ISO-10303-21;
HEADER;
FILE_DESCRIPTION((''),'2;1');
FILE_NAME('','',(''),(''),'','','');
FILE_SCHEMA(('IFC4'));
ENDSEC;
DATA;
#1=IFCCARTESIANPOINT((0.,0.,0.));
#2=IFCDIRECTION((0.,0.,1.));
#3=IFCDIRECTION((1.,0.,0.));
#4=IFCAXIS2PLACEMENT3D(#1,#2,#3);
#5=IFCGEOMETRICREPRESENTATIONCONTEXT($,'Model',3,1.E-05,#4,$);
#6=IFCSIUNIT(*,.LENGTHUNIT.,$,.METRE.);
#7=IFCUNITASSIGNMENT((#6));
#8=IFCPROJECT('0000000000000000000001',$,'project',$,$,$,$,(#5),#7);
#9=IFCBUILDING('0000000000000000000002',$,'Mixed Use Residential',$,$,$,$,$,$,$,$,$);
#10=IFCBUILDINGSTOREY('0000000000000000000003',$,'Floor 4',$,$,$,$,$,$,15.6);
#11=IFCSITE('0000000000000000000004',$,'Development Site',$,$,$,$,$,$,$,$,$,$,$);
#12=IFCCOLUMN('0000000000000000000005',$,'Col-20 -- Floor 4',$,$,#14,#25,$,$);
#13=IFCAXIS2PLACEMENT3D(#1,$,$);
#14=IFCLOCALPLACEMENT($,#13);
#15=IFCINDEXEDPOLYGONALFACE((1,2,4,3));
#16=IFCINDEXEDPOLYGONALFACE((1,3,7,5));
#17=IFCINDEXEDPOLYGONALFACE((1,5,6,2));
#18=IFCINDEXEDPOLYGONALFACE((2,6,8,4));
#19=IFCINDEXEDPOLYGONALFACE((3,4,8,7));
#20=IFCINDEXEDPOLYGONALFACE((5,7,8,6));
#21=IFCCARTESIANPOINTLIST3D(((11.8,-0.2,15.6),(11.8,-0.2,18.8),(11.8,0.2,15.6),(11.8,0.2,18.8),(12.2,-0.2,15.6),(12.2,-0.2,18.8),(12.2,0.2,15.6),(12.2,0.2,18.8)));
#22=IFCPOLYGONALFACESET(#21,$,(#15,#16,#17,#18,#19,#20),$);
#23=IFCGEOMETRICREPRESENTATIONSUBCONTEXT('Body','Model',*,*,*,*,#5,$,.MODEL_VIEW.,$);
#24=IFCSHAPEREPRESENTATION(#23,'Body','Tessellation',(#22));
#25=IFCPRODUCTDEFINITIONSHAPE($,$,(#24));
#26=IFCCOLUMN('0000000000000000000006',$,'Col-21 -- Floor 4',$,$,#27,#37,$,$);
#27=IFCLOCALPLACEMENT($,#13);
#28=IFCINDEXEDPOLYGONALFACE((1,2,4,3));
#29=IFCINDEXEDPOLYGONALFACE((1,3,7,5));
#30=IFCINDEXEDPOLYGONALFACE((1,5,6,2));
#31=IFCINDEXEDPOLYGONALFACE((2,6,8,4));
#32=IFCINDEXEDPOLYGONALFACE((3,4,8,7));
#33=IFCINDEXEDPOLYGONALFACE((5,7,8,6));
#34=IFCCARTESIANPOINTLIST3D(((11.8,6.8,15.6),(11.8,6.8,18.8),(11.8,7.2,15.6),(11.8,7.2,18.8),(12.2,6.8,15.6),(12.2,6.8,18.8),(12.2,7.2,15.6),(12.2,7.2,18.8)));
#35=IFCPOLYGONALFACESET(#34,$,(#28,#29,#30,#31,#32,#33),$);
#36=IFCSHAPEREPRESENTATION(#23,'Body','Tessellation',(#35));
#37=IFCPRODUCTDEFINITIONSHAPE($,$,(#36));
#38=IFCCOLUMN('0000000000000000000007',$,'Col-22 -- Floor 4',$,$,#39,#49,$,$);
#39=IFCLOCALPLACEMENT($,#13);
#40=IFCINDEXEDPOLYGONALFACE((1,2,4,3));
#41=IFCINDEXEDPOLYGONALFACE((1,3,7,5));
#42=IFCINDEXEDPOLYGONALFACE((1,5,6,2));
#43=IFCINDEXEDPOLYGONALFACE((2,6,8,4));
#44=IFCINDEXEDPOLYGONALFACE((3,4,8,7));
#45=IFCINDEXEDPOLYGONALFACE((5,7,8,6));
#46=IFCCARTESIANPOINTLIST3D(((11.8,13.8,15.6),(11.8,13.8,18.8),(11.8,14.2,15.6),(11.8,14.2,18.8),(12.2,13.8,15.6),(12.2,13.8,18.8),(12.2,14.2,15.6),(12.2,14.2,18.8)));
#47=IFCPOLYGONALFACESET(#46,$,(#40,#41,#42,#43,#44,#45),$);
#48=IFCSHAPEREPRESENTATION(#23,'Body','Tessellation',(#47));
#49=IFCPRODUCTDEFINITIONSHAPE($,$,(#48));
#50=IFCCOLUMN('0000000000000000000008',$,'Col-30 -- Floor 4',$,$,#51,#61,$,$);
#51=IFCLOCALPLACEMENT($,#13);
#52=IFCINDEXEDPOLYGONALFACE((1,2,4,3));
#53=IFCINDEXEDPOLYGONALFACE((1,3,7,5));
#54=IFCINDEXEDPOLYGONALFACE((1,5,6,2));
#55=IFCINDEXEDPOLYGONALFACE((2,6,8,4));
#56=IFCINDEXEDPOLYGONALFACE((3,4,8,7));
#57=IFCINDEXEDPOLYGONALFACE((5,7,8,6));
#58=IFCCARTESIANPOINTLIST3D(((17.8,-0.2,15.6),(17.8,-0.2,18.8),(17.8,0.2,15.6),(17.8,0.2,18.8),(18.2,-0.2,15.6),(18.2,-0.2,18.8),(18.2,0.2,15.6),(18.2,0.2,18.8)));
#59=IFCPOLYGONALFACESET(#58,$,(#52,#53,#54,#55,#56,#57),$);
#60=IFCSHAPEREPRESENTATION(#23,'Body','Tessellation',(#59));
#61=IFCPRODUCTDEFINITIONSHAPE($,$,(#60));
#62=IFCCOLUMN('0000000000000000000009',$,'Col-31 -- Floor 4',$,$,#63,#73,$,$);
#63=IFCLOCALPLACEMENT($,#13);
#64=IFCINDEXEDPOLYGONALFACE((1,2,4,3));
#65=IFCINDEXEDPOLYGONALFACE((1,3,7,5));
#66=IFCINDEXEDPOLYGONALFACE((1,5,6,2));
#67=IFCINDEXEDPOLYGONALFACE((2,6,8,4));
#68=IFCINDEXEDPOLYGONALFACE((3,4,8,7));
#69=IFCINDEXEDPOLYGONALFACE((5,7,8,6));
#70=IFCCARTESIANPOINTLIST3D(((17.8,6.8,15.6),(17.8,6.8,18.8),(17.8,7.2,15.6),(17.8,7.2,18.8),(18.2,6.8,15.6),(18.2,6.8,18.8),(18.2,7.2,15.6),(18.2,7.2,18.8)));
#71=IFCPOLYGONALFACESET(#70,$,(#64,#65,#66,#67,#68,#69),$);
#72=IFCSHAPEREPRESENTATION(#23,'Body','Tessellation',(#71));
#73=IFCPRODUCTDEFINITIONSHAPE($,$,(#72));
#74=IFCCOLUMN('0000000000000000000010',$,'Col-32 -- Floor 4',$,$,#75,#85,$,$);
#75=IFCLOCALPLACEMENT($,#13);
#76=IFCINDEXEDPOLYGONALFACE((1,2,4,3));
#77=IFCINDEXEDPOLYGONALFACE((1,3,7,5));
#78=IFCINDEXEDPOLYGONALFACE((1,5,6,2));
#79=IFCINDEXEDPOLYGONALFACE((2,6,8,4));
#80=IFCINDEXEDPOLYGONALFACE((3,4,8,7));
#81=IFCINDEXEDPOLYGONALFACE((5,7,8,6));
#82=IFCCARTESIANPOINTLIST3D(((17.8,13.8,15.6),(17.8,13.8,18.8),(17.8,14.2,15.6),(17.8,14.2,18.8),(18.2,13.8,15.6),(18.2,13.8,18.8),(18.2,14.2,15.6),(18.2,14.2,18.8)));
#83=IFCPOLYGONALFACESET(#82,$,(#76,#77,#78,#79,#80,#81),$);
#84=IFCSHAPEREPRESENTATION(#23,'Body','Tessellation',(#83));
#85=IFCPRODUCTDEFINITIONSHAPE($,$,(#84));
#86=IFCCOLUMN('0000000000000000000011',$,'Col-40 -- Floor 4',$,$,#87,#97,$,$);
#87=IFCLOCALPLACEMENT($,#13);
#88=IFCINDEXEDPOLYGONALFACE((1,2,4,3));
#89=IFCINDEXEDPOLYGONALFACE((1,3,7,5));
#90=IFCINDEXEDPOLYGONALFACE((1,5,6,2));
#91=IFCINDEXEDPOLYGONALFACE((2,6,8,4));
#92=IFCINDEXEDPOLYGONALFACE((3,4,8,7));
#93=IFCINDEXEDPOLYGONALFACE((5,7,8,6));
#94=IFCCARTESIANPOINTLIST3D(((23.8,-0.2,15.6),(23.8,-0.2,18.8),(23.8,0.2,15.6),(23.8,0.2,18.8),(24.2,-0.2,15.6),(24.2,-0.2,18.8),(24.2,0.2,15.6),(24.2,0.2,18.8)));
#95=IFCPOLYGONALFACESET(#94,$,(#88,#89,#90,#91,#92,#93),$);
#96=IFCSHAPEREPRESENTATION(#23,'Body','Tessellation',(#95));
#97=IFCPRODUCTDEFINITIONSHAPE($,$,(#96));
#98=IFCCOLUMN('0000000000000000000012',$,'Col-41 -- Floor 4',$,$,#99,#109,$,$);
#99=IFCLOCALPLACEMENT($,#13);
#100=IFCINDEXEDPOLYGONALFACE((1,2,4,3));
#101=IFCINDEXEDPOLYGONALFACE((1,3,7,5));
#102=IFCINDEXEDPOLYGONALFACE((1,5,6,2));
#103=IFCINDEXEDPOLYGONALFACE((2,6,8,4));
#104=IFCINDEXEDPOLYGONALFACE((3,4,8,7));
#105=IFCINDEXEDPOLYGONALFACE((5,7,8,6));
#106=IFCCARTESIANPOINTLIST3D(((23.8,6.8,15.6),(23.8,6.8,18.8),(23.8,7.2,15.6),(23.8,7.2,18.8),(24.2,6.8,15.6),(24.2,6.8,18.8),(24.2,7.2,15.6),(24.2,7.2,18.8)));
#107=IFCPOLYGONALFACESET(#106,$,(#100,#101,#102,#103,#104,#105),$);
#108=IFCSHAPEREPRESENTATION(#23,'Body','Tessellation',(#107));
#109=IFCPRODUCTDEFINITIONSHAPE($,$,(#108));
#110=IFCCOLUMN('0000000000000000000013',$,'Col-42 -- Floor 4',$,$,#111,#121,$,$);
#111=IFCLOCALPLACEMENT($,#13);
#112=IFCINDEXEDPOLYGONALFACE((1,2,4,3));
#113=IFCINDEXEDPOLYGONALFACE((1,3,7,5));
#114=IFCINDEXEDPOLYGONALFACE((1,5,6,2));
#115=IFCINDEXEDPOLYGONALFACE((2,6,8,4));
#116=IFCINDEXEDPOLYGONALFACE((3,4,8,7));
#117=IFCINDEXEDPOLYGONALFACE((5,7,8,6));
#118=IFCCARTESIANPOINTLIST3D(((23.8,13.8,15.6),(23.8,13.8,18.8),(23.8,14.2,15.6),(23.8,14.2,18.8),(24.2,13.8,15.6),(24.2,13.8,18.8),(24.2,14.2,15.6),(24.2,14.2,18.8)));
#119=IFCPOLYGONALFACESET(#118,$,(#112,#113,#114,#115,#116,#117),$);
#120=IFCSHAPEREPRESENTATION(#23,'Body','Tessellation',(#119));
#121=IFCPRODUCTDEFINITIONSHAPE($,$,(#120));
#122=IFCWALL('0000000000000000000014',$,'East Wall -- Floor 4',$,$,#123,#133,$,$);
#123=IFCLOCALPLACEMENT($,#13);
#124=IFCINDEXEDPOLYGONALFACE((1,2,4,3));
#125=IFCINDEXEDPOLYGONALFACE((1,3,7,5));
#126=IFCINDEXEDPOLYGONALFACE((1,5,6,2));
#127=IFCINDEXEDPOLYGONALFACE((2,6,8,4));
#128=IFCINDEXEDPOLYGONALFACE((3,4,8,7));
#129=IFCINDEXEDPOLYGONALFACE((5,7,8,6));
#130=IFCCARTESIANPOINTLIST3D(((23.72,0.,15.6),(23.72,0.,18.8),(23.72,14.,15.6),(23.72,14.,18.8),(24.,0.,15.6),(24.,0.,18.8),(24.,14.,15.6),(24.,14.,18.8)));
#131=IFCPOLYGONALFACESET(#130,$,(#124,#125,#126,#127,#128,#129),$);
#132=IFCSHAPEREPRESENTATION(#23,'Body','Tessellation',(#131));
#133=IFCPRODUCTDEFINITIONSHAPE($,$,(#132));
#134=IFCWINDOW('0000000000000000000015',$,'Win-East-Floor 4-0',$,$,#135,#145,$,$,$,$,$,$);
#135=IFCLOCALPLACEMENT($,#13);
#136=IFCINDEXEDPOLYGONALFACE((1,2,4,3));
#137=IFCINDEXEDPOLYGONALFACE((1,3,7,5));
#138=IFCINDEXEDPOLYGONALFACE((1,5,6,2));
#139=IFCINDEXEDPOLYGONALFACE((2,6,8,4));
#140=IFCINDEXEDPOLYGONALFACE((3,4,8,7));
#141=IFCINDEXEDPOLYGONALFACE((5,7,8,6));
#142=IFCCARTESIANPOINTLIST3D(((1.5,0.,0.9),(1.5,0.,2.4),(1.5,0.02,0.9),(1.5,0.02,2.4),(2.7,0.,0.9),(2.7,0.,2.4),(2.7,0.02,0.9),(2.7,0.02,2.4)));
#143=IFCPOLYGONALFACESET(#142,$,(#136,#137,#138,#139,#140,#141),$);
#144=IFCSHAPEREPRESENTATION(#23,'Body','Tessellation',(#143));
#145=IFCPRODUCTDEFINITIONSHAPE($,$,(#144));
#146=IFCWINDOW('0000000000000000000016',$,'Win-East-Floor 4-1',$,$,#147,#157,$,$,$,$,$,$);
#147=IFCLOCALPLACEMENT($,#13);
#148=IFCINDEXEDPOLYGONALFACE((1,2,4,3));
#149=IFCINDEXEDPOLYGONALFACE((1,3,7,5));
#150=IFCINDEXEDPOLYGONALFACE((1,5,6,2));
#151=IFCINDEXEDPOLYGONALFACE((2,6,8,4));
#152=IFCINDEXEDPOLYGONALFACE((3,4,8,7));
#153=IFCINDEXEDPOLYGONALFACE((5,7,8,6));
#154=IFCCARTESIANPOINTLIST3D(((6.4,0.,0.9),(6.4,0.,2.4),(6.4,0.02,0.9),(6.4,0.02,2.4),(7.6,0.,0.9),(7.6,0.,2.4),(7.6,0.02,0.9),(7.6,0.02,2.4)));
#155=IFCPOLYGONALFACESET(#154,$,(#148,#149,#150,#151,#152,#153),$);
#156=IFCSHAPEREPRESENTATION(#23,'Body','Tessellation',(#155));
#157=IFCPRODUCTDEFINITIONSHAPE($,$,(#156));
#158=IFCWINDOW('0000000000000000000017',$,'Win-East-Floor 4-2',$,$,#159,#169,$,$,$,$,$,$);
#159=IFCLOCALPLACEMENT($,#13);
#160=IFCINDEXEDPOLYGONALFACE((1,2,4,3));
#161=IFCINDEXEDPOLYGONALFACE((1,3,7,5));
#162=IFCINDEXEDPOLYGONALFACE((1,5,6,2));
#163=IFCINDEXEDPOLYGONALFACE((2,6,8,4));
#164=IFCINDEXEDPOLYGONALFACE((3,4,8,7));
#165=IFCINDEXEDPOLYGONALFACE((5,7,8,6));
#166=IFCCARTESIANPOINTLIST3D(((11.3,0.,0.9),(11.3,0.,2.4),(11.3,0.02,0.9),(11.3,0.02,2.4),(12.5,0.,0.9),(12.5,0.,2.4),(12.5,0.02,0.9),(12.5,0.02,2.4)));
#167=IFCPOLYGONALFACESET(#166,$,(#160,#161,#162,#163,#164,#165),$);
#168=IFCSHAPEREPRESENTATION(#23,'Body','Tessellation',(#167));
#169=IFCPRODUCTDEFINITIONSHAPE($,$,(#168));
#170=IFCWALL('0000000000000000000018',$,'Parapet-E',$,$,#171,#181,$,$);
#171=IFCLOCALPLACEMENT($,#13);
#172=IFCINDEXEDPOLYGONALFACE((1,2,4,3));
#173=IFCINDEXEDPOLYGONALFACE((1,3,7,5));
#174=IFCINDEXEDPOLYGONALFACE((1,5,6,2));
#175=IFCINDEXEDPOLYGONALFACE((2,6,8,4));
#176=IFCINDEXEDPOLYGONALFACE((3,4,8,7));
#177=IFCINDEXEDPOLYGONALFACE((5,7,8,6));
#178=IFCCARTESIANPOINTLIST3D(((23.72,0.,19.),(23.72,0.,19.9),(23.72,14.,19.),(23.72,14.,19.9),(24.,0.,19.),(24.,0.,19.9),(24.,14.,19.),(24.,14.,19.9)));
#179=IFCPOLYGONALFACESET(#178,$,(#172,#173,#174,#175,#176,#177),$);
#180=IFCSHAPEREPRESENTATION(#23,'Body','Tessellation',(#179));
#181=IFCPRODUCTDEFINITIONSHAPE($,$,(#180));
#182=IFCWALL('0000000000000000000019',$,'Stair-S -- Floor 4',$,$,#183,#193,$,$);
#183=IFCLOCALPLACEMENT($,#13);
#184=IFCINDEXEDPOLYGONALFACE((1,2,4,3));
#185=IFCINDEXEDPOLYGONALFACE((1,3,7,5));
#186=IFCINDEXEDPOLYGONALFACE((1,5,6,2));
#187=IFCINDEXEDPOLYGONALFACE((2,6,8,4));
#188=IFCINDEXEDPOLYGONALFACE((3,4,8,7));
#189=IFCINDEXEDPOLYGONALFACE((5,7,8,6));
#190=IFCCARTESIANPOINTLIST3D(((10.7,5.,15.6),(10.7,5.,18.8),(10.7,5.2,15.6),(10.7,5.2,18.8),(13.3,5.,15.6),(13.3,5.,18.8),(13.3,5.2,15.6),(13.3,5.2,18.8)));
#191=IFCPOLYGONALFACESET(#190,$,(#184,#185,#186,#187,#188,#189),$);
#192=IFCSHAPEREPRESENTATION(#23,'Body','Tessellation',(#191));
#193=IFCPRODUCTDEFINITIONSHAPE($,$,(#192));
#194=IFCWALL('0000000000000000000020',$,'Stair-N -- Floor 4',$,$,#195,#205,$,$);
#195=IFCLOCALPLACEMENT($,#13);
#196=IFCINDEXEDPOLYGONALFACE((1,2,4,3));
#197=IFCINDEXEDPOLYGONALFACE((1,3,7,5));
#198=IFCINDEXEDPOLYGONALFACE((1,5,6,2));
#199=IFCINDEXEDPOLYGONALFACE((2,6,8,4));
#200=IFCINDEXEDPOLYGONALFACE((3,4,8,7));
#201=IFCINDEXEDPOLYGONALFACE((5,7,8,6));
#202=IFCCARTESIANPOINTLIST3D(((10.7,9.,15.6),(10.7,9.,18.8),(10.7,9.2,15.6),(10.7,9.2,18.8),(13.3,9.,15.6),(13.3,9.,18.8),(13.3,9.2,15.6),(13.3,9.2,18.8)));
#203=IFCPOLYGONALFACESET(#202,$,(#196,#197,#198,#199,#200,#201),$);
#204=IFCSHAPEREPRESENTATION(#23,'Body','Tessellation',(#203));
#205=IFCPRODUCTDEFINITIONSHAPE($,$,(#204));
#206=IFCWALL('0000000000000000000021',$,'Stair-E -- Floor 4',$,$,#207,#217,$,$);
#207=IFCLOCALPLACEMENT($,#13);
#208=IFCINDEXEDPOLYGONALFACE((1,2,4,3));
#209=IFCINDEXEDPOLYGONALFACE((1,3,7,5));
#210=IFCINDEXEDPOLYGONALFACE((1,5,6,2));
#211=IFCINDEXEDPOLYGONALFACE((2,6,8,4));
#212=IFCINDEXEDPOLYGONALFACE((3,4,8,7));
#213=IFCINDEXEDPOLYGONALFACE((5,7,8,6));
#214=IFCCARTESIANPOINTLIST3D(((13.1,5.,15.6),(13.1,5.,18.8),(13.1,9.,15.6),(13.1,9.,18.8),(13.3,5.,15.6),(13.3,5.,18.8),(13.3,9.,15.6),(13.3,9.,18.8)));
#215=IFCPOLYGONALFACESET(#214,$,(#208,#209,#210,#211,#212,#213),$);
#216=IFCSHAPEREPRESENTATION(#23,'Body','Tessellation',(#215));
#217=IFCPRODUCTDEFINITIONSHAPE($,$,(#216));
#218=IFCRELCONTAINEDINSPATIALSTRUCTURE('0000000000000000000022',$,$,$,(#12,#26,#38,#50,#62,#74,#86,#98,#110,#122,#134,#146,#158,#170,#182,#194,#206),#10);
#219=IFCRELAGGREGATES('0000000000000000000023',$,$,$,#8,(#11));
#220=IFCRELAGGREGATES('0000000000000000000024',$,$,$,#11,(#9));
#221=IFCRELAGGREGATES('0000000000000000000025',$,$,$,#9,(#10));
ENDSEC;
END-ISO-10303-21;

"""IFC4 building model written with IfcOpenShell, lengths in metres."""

from ifc_helpers import new_model, si_unit, frame, origin_with_axes, place, context, subcontext, project, spatial, indexed_curve, rectangle, outline, extrude, element, fill, save


model = new_model("IFC4")

# Units and contexts
model_context = context("Model", 3, precision=1e-05, world=origin_with_axes())
body_context = subcontext(model_context, "Body", "Model", "MODEL_VIEW")
ifc_project = project(units=[si_unit("LENGTHUNIT", "METRE")], contexts=[model_context])

# Site, building, storey
site = spatial("IfcSite", under=ifc_project, Name="Development Site")
building = spatial("IfcBuilding", under=site, Name="Mixed Use Residential")
storey = spatial("IfcBuildingStorey", under=building, Name="Floor 4", Elevation=15.6)

# Columns
for number, where, z_axis, x_axis, name in (
    (1, (12.0, 0.0, 15.6), (0.0, 0.0, 1.0), (1.0, 0.0, 0.0), "Col-20 -- Floor 4"),
    (2, (12.0, 7.0, 15.6), (0.0, 0.0, 1.0), (1.0, 0.0, 0.0), "Col-21 -- Floor 4"),
    (3, (12.0, 14.0, 15.6), (0.0, 0.0, 1.0), (1.0, 0.0, 0.0), "Col-22 -- Floor 4"),
    (4, (18.0, 0.0, 15.6), (0.0, 0.0, 1.0), (1.0, 0.0, 0.0), "Col-30 -- Floor 4"),
    (5, (18.0, 7.0, 15.6), (0.0, 0.0, 1.0), (1.0, 0.0, 0.0), "Col-31 -- Floor 4"),
    (6, (18.0, 14.0, 15.6), (0.0, 0.0, 1.0), (1.0, 0.0, 0.0), "Col-32 -- Floor 4"),
    (7, (24.0, 0.0, 15.6), (0.0, 0.0, 1.0), (1.0, 0.0, 0.0), "Col-40 -- Floor 4"),
    (8, (24.0, 7.0, 15.6), (0.0, 0.0, 1.0), (1.0, 0.0, 0.0), "Col-41 -- Floor 4"),
    (9, (24.0, 14.0, 15.6), (0.0, 0.0, 1.0), (1.0, 0.0, 0.0), "Col-42 -- Floor 4"),
):
    element("IfcColumn", number, at=place(None, frame(where, z_axis=z_axis, x_axis=x_axis)), inside=storey, Name=name, context=body_context, shape_type="SweptSolid", body=[
        extrude(rectangle(XDim=0.4, YDim=0.4), origin_with_axes(), (0.0, 0.0, 1.0), 3.2),
    ])

# Wall, openings, windows
wall_1_placement = place(None, frame((24.0, 0.0, 15.6), z_axis=(0.0, 0.0, 1.0), x_axis=(0.0, 1.0, 0.0)))
wall_1 = element("IfcWall", 10, at=wall_1_placement, inside=storey, Name="East Wall -- Floor 4", context=body_context, shape_type="SweptSolid", body=[
    extrude(outline(indexed_curve([(0.0, 0.0), (0.0, 0.28), (14.0, 0.28), (14.0, 0.0), (0.0, 0.0)], self_intersect=False)), origin_with_axes(), (0.0, 0.0, 1.0), 3.2),
])
opening_1_placement = place(wall_1_placement, frame((0.0, 22.5, -14.7), z_axis=(0.0, 0.0, 1.0), x_axis=(0.0, -1.0, 0.0)))
opening_1 = element("IfcOpeningElement", 11, at=opening_1_placement, cuts=wall_1, context=body_context, shape_type="SweptSolid", body=[
    extrude(outline(indexed_curve([(0.0, 0.0), (0.0, 0.28), (1.2, 0.28), (1.2, 0.0), (0.0, 0.0)], self_intersect=False)), origin_with_axes(), (0.0, 0.0, 1.0), 1.5),
])
opening_2_placement = place(wall_1_placement, frame((0.0, 17.6, -14.7), z_axis=(0.0, 0.0, 1.0), x_axis=(0.0, -1.0, 0.0)))
opening_2 = element("IfcOpeningElement", 12, at=opening_2_placement, cuts=wall_1, context=body_context, shape_type="SweptSolid", body=[
    extrude(outline(indexed_curve([(0.0, 0.0), (0.0, 0.28), (1.2, 0.28), (1.2, 0.0), (0.0, 0.0)], self_intersect=False)), origin_with_axes(), (0.0, 0.0, 1.0), 1.5),
])
opening_3_placement = place(wall_1_placement, frame((0.0, 12.7, -14.7), z_axis=(0.0, 0.0, 1.0), x_axis=(0.0, -1.0, 0.0)))
opening_3 = element("IfcOpeningElement", 13, at=opening_3_placement, cuts=wall_1, context=body_context, shape_type="SweptSolid", body=[
    extrude(outline(indexed_curve([(0.0, 0.0), (0.0, 0.28), (1.2, 0.28), (1.2, 0.0), (0.0, 0.0)], self_intersect=False)), origin_with_axes(), (0.0, 0.0, 1.0), 1.5),
])
window_1_placement = place(None, frame((1.5, 0.0, 0.9), z_axis=(0.0, 0.0, 1.0), x_axis=(1.0, 0.0, 0.0)))
window_1 = element("IfcWindow", 14, at=window_1_placement, inside=storey, Name="Win-East-Floor 4-0", context=body_context, shape_type="SweptSolid", body=[
    extrude(outline(indexed_curve([(0.0, 0.0), (0.0, 0.02), (1.2, 0.02), (1.2, 0.0), (0.0, 0.0)], self_intersect=False)), origin_with_axes(), (0.0, 0.0, 1.0), 1.5),
])
fill(opening_1, window_1)
window_2_placement = place(None, frame((6.4, 0.0, 0.9), z_axis=(0.0, 0.0, 1.0), x_axis=(1.0, 0.0, 0.0)))
window_2 = element("IfcWindow", 15, at=window_2_placement, inside=storey, Name="Win-East-Floor 4-1", context=body_context, shape_type="SweptSolid", body=[
    extrude(outline(indexed_curve([(0.0, 0.0), (0.0, 0.02), (1.2, 0.02), (1.2, 0.0), (0.0, 0.0)], self_intersect=False)), origin_with_axes(), (0.0, 0.0, 1.0), 1.5),
])
fill(opening_2, window_2)
window_3_placement = place(None, frame((11.3, 0.0, 0.9), z_axis=(0.0, 0.0, 1.0), x_axis=(1.0, 0.0, 0.0)))
window_3 = element("IfcWindow", 16, at=window_3_placement, inside=storey, Name="Win-East-Floor 4-2", context=body_context, shape_type="SweptSolid", body=[
    extrude(outline(indexed_curve([(0.0, 0.0), (0.0, 0.02), (1.2, 0.02), (1.2, 0.0), (0.0, 0.0)], self_intersect=False)), origin_with_axes(), (0.0, 0.0, 1.0), 1.5),
])
fill(opening_3, window_3)

# Walls
wall_2_placement = place(None, frame((24.0, 0.0, 19.0), z_axis=(0.0, 0.0, 1.0), x_axis=(0.0, 1.0, 0.0)))
element("IfcWall", 17, at=wall_2_placement, inside=storey, Name="Parapet-E", context=body_context, shape_type="SweptSolid", body=[
    extrude(outline(indexed_curve([(0.0, 0.0), (0.0, 0.28), (14.0, 0.28), (14.0, 0.0), (0.0, 0.0)], self_intersect=False)), origin_with_axes(), (0.0, 0.0, 1.0), 0.9),
])
for number, where, z_axis, x_axis, name in (
    (18, (10.7, 5.0, 15.6), (0.0, 0.0, 1.0), (1.0, 0.0, 0.0), "Stair-S -- Floor 4"),
    (19, (10.7, 9.0, 15.6), (0.0, 0.0, 1.0), (1.0, 0.0, 0.0), "Stair-N -- Floor 4"),
):
    element("IfcWall", number, at=place(None, frame(where, z_axis=z_axis, x_axis=x_axis)), inside=storey, Name=name, context=body_context, shape_type="SweptSolid", body=[
        extrude(outline(indexed_curve([(0.0, 0.0), (0.0, 0.2), (2.6, 0.2), (2.6, 0.0), (0.0, 0.0)], self_intersect=False)), origin_with_axes(), (0.0, 0.0, 1.0), 3.2),
    ])
for number, where, z_axis, x_axis, name in (
    (20, (13.3, 5.0, 15.6), (0.0, 0.0, 1.0), (0.0, 1.0, 0.0), "Stair-E -- Floor 4"),
):
    element("IfcWall", number, at=place(None, frame(where, z_axis=z_axis, x_axis=x_axis)), inside=storey, Name=name, context=body_context, shape_type="SweptSolid", body=[
        extrude(outline(indexed_curve([(0.0, 0.0), (0.0, 0.2), (4.0, 0.2), (4.0, 0.0), (0.0, 0.0)], self_intersect=False)), origin_with_axes(), (0.0, 0.0, 1.0), 3.2),
    ])

save(model, "model.ifc")
